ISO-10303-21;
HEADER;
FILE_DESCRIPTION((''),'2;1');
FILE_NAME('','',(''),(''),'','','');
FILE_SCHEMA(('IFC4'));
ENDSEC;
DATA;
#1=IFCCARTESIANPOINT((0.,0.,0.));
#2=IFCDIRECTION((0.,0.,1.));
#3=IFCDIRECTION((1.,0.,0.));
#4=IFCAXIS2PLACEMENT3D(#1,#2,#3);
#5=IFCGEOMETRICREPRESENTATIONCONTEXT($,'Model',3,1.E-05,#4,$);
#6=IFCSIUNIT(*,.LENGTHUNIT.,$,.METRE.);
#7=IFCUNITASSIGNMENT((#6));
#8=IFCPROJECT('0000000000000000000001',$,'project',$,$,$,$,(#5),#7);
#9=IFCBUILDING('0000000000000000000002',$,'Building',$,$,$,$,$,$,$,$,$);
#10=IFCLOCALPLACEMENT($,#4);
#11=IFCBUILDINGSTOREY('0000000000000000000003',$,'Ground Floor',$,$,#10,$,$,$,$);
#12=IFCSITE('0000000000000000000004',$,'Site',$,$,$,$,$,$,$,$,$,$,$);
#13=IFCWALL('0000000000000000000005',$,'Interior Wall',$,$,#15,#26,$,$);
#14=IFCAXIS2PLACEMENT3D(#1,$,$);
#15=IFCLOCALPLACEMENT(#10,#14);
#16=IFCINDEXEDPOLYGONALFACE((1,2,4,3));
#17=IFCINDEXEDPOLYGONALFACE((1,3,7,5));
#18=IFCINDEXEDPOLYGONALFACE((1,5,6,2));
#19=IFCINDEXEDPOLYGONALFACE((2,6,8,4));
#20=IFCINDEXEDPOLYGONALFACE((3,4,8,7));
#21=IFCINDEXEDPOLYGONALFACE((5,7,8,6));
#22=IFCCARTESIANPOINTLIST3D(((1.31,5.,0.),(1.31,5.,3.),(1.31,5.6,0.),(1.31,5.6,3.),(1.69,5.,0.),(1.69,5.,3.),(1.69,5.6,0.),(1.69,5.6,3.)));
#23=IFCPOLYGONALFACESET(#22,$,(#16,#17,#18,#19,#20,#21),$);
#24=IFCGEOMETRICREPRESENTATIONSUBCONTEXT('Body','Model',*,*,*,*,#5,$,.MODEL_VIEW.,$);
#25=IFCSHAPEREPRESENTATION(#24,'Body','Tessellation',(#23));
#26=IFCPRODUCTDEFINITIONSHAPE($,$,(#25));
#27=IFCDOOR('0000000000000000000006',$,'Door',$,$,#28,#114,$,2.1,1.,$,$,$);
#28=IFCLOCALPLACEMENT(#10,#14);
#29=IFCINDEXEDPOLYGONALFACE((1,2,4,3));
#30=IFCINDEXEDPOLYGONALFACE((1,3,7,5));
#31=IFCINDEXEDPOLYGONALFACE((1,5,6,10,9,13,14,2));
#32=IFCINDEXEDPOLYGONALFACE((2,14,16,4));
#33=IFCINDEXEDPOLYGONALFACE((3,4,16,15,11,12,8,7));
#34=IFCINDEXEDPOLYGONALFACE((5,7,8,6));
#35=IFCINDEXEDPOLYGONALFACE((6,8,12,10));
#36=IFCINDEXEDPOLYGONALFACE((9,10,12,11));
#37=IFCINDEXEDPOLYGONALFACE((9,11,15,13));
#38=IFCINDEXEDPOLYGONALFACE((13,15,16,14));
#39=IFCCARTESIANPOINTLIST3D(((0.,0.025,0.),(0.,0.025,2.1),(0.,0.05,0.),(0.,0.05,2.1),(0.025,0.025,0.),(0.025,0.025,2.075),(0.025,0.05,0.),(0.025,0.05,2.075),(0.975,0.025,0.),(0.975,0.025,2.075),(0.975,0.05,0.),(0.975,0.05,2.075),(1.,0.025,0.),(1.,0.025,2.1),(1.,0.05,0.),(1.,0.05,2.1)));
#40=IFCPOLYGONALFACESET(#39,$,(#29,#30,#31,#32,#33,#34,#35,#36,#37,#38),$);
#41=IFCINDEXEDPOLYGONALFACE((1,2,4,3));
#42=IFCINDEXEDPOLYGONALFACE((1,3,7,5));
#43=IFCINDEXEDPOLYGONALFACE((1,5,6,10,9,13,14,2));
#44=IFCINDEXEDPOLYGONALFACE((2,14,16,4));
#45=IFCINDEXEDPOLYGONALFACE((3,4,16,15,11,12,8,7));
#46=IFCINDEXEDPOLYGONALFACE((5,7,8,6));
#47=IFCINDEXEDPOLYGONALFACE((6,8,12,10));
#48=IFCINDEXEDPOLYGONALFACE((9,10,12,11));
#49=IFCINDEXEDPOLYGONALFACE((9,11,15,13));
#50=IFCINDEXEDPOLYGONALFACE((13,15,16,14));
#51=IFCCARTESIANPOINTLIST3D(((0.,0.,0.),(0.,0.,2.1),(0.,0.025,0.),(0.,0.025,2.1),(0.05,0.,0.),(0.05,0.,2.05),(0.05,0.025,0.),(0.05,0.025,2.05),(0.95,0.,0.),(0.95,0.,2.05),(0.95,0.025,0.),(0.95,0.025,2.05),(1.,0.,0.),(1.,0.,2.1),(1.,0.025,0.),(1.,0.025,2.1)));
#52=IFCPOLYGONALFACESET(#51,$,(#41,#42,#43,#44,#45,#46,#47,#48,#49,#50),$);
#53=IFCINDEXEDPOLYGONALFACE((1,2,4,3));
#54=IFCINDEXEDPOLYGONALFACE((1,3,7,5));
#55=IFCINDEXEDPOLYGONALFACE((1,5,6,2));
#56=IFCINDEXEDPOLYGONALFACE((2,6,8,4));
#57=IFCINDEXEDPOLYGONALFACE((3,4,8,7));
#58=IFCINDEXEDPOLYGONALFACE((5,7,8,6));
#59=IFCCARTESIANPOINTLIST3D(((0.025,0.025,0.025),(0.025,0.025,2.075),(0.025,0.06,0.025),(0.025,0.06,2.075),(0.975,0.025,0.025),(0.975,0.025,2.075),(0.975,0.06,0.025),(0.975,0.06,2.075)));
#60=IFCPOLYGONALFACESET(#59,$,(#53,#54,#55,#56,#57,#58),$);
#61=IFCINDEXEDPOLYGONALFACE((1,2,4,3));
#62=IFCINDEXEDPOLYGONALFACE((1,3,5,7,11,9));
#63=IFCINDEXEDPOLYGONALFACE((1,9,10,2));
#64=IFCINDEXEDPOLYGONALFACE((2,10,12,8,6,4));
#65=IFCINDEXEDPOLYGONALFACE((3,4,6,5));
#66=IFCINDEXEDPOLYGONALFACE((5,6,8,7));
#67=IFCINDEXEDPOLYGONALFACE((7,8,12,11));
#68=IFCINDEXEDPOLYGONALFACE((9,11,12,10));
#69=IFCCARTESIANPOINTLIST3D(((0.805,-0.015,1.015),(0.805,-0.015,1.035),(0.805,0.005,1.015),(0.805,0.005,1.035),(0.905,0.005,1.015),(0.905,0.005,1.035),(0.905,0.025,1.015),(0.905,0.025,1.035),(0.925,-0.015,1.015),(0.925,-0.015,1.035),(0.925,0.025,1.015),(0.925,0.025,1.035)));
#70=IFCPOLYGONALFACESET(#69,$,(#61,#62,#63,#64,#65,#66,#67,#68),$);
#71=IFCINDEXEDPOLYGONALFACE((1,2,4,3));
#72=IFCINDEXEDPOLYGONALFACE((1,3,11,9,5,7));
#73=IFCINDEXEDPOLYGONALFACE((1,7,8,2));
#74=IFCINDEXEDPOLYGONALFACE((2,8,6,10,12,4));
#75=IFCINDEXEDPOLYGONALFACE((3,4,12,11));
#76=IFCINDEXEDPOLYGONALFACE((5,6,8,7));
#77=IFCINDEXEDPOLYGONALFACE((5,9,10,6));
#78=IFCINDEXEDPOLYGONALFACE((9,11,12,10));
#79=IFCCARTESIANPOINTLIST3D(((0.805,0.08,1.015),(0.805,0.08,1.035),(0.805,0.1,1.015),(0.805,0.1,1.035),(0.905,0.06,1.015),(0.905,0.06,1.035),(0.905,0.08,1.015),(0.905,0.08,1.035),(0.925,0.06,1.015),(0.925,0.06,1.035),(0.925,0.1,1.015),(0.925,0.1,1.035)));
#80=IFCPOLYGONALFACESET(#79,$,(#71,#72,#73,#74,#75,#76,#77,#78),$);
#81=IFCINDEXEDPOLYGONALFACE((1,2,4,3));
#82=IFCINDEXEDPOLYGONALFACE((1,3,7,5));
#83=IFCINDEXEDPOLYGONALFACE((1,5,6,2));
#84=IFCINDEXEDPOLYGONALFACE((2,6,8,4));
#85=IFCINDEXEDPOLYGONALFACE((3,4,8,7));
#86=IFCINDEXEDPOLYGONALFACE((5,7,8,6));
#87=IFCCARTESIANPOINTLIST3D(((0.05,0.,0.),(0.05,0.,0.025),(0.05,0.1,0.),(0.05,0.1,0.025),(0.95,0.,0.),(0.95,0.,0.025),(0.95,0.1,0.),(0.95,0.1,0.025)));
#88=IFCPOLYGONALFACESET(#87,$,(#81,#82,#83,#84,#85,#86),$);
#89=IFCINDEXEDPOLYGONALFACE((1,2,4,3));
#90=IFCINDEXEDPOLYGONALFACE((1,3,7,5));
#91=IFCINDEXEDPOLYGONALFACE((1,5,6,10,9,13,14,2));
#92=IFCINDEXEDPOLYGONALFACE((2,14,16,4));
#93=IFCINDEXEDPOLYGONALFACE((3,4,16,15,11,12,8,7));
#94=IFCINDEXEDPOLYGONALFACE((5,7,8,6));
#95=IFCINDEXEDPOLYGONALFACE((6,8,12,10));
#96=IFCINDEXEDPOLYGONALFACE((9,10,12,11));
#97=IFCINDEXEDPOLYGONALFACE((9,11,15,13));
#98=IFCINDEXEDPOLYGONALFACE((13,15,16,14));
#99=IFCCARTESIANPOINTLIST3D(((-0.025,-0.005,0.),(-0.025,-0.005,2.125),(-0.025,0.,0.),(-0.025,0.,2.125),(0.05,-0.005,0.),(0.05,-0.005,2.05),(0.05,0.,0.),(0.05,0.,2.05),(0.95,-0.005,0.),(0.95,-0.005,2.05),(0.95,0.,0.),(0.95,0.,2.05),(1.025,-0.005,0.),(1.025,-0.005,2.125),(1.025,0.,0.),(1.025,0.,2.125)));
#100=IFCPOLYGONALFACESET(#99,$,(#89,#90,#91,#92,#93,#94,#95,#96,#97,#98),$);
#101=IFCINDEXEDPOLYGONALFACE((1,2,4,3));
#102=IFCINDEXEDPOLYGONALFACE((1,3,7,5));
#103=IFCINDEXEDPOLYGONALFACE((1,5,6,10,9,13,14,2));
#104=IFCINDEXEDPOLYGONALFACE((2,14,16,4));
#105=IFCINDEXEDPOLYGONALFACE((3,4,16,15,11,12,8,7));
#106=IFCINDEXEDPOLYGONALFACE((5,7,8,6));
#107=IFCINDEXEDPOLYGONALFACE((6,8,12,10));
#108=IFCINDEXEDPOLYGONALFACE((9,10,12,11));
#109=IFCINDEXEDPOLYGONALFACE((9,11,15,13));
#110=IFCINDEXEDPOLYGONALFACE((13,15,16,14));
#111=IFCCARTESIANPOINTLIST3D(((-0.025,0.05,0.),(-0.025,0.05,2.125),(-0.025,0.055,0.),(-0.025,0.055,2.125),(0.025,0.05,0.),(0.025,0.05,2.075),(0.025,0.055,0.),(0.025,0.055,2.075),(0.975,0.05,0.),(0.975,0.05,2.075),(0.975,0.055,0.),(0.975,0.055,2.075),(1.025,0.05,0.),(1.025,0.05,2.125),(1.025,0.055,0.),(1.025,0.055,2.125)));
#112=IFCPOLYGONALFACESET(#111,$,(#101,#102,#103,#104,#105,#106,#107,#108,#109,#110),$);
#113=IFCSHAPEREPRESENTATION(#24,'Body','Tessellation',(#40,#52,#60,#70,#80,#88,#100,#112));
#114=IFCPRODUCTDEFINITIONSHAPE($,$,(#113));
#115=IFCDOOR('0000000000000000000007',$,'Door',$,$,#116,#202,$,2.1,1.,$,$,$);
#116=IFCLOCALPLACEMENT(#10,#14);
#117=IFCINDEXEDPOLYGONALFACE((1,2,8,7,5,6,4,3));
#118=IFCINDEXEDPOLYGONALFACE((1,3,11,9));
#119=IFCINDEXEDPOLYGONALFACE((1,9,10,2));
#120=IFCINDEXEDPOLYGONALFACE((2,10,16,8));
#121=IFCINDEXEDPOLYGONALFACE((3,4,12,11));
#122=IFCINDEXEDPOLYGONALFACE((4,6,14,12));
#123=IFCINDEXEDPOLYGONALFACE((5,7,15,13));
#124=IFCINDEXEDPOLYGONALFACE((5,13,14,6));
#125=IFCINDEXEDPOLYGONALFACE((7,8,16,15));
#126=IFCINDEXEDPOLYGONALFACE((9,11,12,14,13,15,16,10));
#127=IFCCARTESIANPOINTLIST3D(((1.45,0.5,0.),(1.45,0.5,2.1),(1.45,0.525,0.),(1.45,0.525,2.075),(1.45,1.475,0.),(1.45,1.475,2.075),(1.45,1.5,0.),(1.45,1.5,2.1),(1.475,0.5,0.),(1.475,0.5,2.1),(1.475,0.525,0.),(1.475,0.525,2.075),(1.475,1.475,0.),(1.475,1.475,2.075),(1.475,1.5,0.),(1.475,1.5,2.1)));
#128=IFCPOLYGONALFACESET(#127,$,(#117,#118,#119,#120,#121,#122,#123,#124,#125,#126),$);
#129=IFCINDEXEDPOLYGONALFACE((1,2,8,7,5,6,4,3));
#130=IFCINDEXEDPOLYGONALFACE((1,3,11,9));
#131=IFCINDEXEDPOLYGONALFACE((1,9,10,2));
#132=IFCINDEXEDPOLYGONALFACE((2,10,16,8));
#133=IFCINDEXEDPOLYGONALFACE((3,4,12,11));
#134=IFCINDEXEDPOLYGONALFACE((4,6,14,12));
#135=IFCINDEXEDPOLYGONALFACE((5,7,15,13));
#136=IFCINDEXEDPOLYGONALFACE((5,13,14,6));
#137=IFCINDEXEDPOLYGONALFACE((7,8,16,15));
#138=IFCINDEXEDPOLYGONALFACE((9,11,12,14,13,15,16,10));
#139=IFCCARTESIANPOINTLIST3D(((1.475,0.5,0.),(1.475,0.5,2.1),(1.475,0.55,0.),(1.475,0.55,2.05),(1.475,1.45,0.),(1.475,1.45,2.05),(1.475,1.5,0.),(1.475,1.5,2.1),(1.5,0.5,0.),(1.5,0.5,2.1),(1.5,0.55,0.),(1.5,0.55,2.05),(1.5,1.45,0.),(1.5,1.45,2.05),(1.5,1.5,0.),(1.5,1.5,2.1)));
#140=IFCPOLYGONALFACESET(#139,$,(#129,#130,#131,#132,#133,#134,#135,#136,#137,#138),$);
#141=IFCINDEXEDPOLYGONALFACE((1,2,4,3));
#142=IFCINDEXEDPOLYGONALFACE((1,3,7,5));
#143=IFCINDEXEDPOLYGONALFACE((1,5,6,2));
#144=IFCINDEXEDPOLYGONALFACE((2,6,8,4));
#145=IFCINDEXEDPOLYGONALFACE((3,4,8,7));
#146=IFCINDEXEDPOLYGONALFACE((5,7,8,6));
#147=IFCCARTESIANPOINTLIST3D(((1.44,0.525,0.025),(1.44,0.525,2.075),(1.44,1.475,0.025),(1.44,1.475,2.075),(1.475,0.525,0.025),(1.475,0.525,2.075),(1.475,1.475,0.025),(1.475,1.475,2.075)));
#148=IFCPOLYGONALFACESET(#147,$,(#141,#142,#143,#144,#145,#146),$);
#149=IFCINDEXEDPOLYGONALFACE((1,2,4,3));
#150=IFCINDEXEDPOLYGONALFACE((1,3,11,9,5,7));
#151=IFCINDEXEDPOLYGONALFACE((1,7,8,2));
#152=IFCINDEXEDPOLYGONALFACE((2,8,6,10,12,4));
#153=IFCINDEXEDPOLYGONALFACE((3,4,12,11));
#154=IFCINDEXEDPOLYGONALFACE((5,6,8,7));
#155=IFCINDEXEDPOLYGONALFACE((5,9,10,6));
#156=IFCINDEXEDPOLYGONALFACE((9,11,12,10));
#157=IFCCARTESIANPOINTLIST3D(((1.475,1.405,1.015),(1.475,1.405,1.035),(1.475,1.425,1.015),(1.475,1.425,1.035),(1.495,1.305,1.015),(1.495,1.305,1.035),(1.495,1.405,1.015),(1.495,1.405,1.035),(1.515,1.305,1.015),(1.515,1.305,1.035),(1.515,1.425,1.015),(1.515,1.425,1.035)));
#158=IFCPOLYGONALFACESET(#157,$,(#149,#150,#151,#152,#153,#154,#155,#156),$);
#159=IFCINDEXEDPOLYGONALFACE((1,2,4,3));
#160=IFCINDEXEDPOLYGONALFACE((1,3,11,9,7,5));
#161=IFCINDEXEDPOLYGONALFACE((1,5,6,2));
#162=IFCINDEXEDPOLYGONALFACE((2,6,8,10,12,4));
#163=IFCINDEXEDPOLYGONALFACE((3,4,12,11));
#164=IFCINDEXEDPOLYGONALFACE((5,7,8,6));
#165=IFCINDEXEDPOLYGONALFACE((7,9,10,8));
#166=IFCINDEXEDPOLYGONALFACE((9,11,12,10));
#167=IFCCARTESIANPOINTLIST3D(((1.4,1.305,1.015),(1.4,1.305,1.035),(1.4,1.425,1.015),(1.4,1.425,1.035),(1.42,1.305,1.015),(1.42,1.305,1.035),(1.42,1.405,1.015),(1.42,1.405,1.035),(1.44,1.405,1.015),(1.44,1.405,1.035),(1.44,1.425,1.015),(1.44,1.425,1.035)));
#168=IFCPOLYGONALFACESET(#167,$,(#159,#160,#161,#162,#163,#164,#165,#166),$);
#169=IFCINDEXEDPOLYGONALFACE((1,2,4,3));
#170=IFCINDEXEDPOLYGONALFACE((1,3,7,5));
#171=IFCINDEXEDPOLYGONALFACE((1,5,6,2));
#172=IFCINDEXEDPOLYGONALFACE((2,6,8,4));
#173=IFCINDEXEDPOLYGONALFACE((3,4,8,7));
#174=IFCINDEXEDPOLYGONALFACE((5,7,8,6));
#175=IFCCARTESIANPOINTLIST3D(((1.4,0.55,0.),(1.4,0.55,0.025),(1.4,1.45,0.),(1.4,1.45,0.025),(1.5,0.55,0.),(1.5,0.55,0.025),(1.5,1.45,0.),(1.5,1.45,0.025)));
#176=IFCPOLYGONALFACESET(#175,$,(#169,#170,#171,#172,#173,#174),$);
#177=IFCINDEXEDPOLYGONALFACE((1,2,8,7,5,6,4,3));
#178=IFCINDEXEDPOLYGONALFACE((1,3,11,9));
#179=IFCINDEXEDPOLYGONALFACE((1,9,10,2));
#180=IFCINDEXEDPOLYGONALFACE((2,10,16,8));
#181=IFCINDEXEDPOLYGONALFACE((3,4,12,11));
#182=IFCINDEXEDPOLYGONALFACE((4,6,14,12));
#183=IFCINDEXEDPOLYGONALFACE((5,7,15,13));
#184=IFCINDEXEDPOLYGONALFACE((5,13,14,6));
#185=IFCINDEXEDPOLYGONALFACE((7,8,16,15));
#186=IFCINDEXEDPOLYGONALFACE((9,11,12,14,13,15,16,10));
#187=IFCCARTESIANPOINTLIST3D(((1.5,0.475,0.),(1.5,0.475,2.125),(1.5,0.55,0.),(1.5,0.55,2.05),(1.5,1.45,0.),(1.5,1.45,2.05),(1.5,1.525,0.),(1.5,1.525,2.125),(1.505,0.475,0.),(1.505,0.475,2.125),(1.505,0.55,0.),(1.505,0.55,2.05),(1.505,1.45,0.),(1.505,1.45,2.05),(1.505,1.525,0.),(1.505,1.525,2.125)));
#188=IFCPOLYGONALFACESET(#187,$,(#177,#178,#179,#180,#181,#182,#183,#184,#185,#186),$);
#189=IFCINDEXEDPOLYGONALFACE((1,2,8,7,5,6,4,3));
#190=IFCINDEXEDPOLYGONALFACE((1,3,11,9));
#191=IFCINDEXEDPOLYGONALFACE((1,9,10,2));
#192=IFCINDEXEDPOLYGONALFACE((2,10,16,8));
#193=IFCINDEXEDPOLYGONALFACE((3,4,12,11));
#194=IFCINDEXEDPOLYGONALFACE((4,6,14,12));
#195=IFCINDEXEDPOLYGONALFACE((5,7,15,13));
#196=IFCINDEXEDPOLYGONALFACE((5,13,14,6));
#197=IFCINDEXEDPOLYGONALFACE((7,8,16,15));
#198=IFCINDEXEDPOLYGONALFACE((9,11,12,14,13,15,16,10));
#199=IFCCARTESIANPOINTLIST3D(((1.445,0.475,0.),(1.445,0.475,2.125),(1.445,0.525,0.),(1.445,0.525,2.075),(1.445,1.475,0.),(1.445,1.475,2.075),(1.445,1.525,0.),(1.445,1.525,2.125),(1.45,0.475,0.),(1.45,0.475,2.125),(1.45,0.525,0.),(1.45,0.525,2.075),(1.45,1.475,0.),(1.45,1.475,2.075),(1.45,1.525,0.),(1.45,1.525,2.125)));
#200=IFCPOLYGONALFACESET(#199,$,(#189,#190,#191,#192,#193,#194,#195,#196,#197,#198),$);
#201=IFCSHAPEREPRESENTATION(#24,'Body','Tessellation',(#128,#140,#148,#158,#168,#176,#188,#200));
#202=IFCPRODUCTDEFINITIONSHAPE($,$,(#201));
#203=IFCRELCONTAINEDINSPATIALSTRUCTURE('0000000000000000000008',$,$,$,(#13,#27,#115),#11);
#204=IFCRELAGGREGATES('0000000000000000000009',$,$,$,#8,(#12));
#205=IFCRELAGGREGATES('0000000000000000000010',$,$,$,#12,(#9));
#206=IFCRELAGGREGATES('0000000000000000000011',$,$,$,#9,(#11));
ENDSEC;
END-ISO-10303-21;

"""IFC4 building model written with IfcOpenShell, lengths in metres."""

from ifc_helpers import new_model, si_unit, frame, origin_with_axes, place, context, subcontext, project, spatial, line, indexed_curve, outline, extrude, element, save


model = new_model("IFC4")

# Units and contexts
model_context = context("Model", 3, precision=1e-05, world=origin_with_axes())
body_context = subcontext(model_context, "Body", "Model", "MODEL_VIEW")
ifc_project = project(units=[si_unit("LENGTHUNIT", "METRE")], contexts=[model_context])

# Site, building, storey
site = spatial("IfcSite", under=ifc_project, Name="Site")
building = spatial("IfcBuilding", under=site, Name="Building")
storey_placement = place(None, origin_with_axes())
storey = spatial("IfcBuildingStorey", under=building, at=storey_placement, Name="Ground Floor")

# Wall
for number, where, z_axis, x_axis, name in (
    (1, (1.5, 5.6, 0.0), (0.0, 0.0, 1.0), (0.0, -1.0, 0.0), "Interior Wall"),
):
    element("IfcWall", number, at=place(storey_placement, frame(where, z_axis=z_axis, x_axis=x_axis)), inside=storey, Name=name, context=body_context, shape_type="SweptSolid", body=[
        extrude(outline(indexed_curve([(0.0, 0.0), (0.0, 0.38), (0.6, 0.38), (0.6, 0.0), (0.0, 0.0)], self_intersect=False)), frame((0.0, -0.19, 0.0), z_axis=(0.0, 0.0, 1.0), x_axis=(1.0, 0.0, 0.0)), (0.0, 0.0, 1.0), 3.0),
    ])

# Doors
door_1_placement = place(storey_placement, origin_with_axes())
element("IfcDoor", 2, at=door_1_placement, inside=storey, Name="Door", OverallHeight=2.1, OverallWidth=1.0, context=body_context, shape_type="SweptSolid", body=[
    extrude(outline(indexed_curve([(0.0, 0.0), (0.0, 2.1), (1.0, 2.1), (1.0, 0.0), (0.975, 0.0), (0.975, 2.075), (0.025, 2.075), (0.025, 0.0)], segments=[line(1, 2, 3, 4, 5, 6, 7, 8, 1)])), frame((0.0, 0.025, 0.0), z_axis=(0.0, -1.0, 0.0), x_axis=(1.0, 0.0, 0.0)), (0.0, 0.0, -1.0), 0.025),
    extrude(outline(indexed_curve([(0.0, 0.0), (0.0, 2.1), (1.0, 2.1), (1.0, 0.0), (0.95, 0.0), (0.95, 2.05), (0.05, 2.05), (0.05, 0.0)], segments=[line(1, 2, 3, 4, 5, 6, 7, 8, 1)])), frame((0.0, 0.0, 0.0), z_axis=(0.0, -1.0, 0.0), x_axis=(1.0, 0.0, 0.0)), (0.0, 0.0, -1.0), 0.025),
    extrude(outline(indexed_curve([(0.0, 0.0), (0.95, 0.0), (0.95, 0.035), (0.0, 0.035)], segments=[line(1, 2, 3, 4, 1)])), frame((0.025, 0.025, 0.025), z_axis=(0.0, 0.0, 1.0), x_axis=(1.0, 0.0, 0.0)), (0.0, 0.0, 1.0), 2.05),
    extrude(outline(indexed_curve([(0.0, 0.0), (0.0, -0.04), (-0.12, -0.04), (-0.12, -0.02), (-0.02, -0.02), (-0.02, 0.0)], segments=[line(1, 2, 3, 4, 5, 6, 1)])), frame((0.925, 0.025, 1.015), z_axis=(0.0, 0.0, 1.0), x_axis=(1.0, 0.0, 0.0)), (0.0, 0.0, 1.0), 0.02),
    extrude(outline(indexed_curve([(0.0, 0.0), (0.0, 0.04), (-0.12, 0.04), (-0.12, 0.02), (-0.02, 0.02), (-0.02, 0.0)], segments=[line(1, 2, 3, 4, 5, 6, 1)])), frame((0.925, 0.06, 1.015), z_axis=(0.0, 0.0, 1.0), x_axis=(1.0, 0.0, 0.0)), (0.0, 0.0, 1.0), 0.02),
    extrude(outline(indexed_curve([(0.0, 0.0), (0.9, 0.0), (0.9, 0.1), (0.0, 0.1)], segments=[line(1, 2, 3, 4, 1)])), frame((0.05, 0.0, 0.0), z_axis=(0.0, 0.0, 1.0), x_axis=(1.0, 0.0, 0.0)), (0.0, 0.0, 1.0), 0.025),
    extrude(outline(indexed_curve([(0.0, 0.0), (0.0, 2.125), (1.05, 2.125), (1.05, 0.0), (0.975, 0.0), (0.975, 2.05), (0.075, 2.05), (0.075, 0.0)], segments=[line(1, 2, 3, 4, 5, 6, 7, 8, 1)])), frame((-0.025, -0.005, 0.0), z_axis=(0.0, -1.0, 0.0), x_axis=(1.0, 0.0, 0.0)), (0.0, 0.0, -1.0), 0.005),
    extrude(outline(indexed_curve([(0.0, 0.0), (0.0, 2.125), (1.05, 2.125), (1.05, 0.0), (1.0, 0.0), (1.0, 2.075), (0.05, 2.075), (0.05, 0.0)], segments=[line(1, 2, 3, 4, 5, 6, 7, 8, 1)])), frame((-0.025, 0.05, 0.0), z_axis=(0.0, -1.0, 0.0), x_axis=(1.0, 0.0, 0.0)), (0.0, 0.0, -1.0), 0.005),
])
door_2_placement = place(storey_placement, frame((1.5, 0.5, 0.0), z_axis=(0.0, 0.0, 1.0), x_axis=(0.0, 1.0, 0.0)))
element("IfcDoor", 3, at=door_2_placement, inside=storey, Name="Door", OverallHeight=2.1, OverallWidth=1.0, context=body_context, shape_type="SweptSolid", body=[
    extrude(outline(indexed_curve([(0.0, 0.0), (0.0, 2.1), (1.0, 2.1), (1.0, 0.0), (0.975, 0.0), (0.975, 2.075), (0.025, 2.075), (0.025, 0.0)], segments=[line(1, 2, 3, 4, 5, 6, 7, 8, 1)])), frame((0.0, 0.025, 0.0), z_axis=(0.0, -1.0, 0.0), x_axis=(1.0, 0.0, 0.0)), (0.0, 0.0, -1.0), 0.025),
    extrude(outline(indexed_curve([(0.0, 0.0), (0.0, 2.1), (1.0, 2.1), (1.0, 0.0), (0.95, 0.0), (0.95, 2.05), (0.05, 2.05), (0.05, 0.0)], segments=[line(1, 2, 3, 4, 5, 6, 7, 8, 1)])), frame((0.0, 0.0, 0.0), z_axis=(0.0, -1.0, 0.0), x_axis=(1.0, 0.0, 0.0)), (0.0, 0.0, -1.0), 0.025),
    extrude(outline(indexed_curve([(0.0, 0.0), (0.95, 0.0), (0.95, 0.035), (0.0, 0.035)], segments=[line(1, 2, 3, 4, 1)])), frame((0.025, 0.025, 0.025), z_axis=(0.0, 0.0, 1.0), x_axis=(1.0, 0.0, 0.0)), (0.0, 0.0, 1.0), 2.05),
    extrude(outline(indexed_curve([(0.0, 0.0), (0.0, -0.04), (-0.12, -0.04), (-0.12, -0.02), (-0.02, -0.02), (-0.02, 0.0)], segments=[line(1, 2, 3, 4, 5, 6, 1)])), frame((0.925, 0.025, 1.015), z_axis=(0.0, 0.0, 1.0), x_axis=(1.0, 0.0, 0.0)), (0.0, 0.0, 1.0), 0.02),
    extrude(outline(indexed_curve([(0.0, 0.0), (0.0, 0.04), (-0.12, 0.04), (-0.12, 0.02), (-0.02, 0.02), (-0.02, 0.0)], segments=[line(1, 2, 3, 4, 5, 6, 1)])), frame((0.925, 0.06, 1.015), z_axis=(0.0, 0.0, 1.0), x_axis=(1.0, 0.0, 0.0)), (0.0, 0.0, 1.0), 0.02),
    extrude(outline(indexed_curve([(0.0, 0.0), (0.9, 0.0), (0.9, 0.1), (0.0, 0.1)], segments=[line(1, 2, 3, 4, 1)])), frame((0.05, 0.0, 0.0), z_axis=(0.0, 0.0, 1.0), x_axis=(1.0, 0.0, 0.0)), (0.0, 0.0, 1.0), 0.025),
    extrude(outline(indexed_curve([(0.0, 0.0), (0.0, 2.125), (1.05, 2.125), (1.05, 0.0), (0.975, 0.0), (0.975, 2.05), (0.075, 2.05), (0.075, 0.0)], segments=[line(1, 2, 3, 4, 5, 6, 7, 8, 1)])), frame((-0.025, -0.005, 0.0), z_axis=(0.0, -1.0, 0.0), x_axis=(1.0, 0.0, 0.0)), (0.0, 0.0, -1.0), 0.005),
    extrude(outline(indexed_curve([(0.0, 0.0), (0.0, 2.125), (1.05, 2.125), (1.05, 0.0), (1.0, 0.0), (1.0, 2.075), (0.05, 2.075), (0.05, 0.0)], segments=[line(1, 2, 3, 4, 5, 6, 7, 8, 1)])), frame((-0.025, 0.05, 0.0), z_axis=(0.0, -1.0, 0.0), x_axis=(1.0, 0.0, 0.0)), (0.0, 0.0, -1.0), 0.005),
])

save(model, "model.ifc")
